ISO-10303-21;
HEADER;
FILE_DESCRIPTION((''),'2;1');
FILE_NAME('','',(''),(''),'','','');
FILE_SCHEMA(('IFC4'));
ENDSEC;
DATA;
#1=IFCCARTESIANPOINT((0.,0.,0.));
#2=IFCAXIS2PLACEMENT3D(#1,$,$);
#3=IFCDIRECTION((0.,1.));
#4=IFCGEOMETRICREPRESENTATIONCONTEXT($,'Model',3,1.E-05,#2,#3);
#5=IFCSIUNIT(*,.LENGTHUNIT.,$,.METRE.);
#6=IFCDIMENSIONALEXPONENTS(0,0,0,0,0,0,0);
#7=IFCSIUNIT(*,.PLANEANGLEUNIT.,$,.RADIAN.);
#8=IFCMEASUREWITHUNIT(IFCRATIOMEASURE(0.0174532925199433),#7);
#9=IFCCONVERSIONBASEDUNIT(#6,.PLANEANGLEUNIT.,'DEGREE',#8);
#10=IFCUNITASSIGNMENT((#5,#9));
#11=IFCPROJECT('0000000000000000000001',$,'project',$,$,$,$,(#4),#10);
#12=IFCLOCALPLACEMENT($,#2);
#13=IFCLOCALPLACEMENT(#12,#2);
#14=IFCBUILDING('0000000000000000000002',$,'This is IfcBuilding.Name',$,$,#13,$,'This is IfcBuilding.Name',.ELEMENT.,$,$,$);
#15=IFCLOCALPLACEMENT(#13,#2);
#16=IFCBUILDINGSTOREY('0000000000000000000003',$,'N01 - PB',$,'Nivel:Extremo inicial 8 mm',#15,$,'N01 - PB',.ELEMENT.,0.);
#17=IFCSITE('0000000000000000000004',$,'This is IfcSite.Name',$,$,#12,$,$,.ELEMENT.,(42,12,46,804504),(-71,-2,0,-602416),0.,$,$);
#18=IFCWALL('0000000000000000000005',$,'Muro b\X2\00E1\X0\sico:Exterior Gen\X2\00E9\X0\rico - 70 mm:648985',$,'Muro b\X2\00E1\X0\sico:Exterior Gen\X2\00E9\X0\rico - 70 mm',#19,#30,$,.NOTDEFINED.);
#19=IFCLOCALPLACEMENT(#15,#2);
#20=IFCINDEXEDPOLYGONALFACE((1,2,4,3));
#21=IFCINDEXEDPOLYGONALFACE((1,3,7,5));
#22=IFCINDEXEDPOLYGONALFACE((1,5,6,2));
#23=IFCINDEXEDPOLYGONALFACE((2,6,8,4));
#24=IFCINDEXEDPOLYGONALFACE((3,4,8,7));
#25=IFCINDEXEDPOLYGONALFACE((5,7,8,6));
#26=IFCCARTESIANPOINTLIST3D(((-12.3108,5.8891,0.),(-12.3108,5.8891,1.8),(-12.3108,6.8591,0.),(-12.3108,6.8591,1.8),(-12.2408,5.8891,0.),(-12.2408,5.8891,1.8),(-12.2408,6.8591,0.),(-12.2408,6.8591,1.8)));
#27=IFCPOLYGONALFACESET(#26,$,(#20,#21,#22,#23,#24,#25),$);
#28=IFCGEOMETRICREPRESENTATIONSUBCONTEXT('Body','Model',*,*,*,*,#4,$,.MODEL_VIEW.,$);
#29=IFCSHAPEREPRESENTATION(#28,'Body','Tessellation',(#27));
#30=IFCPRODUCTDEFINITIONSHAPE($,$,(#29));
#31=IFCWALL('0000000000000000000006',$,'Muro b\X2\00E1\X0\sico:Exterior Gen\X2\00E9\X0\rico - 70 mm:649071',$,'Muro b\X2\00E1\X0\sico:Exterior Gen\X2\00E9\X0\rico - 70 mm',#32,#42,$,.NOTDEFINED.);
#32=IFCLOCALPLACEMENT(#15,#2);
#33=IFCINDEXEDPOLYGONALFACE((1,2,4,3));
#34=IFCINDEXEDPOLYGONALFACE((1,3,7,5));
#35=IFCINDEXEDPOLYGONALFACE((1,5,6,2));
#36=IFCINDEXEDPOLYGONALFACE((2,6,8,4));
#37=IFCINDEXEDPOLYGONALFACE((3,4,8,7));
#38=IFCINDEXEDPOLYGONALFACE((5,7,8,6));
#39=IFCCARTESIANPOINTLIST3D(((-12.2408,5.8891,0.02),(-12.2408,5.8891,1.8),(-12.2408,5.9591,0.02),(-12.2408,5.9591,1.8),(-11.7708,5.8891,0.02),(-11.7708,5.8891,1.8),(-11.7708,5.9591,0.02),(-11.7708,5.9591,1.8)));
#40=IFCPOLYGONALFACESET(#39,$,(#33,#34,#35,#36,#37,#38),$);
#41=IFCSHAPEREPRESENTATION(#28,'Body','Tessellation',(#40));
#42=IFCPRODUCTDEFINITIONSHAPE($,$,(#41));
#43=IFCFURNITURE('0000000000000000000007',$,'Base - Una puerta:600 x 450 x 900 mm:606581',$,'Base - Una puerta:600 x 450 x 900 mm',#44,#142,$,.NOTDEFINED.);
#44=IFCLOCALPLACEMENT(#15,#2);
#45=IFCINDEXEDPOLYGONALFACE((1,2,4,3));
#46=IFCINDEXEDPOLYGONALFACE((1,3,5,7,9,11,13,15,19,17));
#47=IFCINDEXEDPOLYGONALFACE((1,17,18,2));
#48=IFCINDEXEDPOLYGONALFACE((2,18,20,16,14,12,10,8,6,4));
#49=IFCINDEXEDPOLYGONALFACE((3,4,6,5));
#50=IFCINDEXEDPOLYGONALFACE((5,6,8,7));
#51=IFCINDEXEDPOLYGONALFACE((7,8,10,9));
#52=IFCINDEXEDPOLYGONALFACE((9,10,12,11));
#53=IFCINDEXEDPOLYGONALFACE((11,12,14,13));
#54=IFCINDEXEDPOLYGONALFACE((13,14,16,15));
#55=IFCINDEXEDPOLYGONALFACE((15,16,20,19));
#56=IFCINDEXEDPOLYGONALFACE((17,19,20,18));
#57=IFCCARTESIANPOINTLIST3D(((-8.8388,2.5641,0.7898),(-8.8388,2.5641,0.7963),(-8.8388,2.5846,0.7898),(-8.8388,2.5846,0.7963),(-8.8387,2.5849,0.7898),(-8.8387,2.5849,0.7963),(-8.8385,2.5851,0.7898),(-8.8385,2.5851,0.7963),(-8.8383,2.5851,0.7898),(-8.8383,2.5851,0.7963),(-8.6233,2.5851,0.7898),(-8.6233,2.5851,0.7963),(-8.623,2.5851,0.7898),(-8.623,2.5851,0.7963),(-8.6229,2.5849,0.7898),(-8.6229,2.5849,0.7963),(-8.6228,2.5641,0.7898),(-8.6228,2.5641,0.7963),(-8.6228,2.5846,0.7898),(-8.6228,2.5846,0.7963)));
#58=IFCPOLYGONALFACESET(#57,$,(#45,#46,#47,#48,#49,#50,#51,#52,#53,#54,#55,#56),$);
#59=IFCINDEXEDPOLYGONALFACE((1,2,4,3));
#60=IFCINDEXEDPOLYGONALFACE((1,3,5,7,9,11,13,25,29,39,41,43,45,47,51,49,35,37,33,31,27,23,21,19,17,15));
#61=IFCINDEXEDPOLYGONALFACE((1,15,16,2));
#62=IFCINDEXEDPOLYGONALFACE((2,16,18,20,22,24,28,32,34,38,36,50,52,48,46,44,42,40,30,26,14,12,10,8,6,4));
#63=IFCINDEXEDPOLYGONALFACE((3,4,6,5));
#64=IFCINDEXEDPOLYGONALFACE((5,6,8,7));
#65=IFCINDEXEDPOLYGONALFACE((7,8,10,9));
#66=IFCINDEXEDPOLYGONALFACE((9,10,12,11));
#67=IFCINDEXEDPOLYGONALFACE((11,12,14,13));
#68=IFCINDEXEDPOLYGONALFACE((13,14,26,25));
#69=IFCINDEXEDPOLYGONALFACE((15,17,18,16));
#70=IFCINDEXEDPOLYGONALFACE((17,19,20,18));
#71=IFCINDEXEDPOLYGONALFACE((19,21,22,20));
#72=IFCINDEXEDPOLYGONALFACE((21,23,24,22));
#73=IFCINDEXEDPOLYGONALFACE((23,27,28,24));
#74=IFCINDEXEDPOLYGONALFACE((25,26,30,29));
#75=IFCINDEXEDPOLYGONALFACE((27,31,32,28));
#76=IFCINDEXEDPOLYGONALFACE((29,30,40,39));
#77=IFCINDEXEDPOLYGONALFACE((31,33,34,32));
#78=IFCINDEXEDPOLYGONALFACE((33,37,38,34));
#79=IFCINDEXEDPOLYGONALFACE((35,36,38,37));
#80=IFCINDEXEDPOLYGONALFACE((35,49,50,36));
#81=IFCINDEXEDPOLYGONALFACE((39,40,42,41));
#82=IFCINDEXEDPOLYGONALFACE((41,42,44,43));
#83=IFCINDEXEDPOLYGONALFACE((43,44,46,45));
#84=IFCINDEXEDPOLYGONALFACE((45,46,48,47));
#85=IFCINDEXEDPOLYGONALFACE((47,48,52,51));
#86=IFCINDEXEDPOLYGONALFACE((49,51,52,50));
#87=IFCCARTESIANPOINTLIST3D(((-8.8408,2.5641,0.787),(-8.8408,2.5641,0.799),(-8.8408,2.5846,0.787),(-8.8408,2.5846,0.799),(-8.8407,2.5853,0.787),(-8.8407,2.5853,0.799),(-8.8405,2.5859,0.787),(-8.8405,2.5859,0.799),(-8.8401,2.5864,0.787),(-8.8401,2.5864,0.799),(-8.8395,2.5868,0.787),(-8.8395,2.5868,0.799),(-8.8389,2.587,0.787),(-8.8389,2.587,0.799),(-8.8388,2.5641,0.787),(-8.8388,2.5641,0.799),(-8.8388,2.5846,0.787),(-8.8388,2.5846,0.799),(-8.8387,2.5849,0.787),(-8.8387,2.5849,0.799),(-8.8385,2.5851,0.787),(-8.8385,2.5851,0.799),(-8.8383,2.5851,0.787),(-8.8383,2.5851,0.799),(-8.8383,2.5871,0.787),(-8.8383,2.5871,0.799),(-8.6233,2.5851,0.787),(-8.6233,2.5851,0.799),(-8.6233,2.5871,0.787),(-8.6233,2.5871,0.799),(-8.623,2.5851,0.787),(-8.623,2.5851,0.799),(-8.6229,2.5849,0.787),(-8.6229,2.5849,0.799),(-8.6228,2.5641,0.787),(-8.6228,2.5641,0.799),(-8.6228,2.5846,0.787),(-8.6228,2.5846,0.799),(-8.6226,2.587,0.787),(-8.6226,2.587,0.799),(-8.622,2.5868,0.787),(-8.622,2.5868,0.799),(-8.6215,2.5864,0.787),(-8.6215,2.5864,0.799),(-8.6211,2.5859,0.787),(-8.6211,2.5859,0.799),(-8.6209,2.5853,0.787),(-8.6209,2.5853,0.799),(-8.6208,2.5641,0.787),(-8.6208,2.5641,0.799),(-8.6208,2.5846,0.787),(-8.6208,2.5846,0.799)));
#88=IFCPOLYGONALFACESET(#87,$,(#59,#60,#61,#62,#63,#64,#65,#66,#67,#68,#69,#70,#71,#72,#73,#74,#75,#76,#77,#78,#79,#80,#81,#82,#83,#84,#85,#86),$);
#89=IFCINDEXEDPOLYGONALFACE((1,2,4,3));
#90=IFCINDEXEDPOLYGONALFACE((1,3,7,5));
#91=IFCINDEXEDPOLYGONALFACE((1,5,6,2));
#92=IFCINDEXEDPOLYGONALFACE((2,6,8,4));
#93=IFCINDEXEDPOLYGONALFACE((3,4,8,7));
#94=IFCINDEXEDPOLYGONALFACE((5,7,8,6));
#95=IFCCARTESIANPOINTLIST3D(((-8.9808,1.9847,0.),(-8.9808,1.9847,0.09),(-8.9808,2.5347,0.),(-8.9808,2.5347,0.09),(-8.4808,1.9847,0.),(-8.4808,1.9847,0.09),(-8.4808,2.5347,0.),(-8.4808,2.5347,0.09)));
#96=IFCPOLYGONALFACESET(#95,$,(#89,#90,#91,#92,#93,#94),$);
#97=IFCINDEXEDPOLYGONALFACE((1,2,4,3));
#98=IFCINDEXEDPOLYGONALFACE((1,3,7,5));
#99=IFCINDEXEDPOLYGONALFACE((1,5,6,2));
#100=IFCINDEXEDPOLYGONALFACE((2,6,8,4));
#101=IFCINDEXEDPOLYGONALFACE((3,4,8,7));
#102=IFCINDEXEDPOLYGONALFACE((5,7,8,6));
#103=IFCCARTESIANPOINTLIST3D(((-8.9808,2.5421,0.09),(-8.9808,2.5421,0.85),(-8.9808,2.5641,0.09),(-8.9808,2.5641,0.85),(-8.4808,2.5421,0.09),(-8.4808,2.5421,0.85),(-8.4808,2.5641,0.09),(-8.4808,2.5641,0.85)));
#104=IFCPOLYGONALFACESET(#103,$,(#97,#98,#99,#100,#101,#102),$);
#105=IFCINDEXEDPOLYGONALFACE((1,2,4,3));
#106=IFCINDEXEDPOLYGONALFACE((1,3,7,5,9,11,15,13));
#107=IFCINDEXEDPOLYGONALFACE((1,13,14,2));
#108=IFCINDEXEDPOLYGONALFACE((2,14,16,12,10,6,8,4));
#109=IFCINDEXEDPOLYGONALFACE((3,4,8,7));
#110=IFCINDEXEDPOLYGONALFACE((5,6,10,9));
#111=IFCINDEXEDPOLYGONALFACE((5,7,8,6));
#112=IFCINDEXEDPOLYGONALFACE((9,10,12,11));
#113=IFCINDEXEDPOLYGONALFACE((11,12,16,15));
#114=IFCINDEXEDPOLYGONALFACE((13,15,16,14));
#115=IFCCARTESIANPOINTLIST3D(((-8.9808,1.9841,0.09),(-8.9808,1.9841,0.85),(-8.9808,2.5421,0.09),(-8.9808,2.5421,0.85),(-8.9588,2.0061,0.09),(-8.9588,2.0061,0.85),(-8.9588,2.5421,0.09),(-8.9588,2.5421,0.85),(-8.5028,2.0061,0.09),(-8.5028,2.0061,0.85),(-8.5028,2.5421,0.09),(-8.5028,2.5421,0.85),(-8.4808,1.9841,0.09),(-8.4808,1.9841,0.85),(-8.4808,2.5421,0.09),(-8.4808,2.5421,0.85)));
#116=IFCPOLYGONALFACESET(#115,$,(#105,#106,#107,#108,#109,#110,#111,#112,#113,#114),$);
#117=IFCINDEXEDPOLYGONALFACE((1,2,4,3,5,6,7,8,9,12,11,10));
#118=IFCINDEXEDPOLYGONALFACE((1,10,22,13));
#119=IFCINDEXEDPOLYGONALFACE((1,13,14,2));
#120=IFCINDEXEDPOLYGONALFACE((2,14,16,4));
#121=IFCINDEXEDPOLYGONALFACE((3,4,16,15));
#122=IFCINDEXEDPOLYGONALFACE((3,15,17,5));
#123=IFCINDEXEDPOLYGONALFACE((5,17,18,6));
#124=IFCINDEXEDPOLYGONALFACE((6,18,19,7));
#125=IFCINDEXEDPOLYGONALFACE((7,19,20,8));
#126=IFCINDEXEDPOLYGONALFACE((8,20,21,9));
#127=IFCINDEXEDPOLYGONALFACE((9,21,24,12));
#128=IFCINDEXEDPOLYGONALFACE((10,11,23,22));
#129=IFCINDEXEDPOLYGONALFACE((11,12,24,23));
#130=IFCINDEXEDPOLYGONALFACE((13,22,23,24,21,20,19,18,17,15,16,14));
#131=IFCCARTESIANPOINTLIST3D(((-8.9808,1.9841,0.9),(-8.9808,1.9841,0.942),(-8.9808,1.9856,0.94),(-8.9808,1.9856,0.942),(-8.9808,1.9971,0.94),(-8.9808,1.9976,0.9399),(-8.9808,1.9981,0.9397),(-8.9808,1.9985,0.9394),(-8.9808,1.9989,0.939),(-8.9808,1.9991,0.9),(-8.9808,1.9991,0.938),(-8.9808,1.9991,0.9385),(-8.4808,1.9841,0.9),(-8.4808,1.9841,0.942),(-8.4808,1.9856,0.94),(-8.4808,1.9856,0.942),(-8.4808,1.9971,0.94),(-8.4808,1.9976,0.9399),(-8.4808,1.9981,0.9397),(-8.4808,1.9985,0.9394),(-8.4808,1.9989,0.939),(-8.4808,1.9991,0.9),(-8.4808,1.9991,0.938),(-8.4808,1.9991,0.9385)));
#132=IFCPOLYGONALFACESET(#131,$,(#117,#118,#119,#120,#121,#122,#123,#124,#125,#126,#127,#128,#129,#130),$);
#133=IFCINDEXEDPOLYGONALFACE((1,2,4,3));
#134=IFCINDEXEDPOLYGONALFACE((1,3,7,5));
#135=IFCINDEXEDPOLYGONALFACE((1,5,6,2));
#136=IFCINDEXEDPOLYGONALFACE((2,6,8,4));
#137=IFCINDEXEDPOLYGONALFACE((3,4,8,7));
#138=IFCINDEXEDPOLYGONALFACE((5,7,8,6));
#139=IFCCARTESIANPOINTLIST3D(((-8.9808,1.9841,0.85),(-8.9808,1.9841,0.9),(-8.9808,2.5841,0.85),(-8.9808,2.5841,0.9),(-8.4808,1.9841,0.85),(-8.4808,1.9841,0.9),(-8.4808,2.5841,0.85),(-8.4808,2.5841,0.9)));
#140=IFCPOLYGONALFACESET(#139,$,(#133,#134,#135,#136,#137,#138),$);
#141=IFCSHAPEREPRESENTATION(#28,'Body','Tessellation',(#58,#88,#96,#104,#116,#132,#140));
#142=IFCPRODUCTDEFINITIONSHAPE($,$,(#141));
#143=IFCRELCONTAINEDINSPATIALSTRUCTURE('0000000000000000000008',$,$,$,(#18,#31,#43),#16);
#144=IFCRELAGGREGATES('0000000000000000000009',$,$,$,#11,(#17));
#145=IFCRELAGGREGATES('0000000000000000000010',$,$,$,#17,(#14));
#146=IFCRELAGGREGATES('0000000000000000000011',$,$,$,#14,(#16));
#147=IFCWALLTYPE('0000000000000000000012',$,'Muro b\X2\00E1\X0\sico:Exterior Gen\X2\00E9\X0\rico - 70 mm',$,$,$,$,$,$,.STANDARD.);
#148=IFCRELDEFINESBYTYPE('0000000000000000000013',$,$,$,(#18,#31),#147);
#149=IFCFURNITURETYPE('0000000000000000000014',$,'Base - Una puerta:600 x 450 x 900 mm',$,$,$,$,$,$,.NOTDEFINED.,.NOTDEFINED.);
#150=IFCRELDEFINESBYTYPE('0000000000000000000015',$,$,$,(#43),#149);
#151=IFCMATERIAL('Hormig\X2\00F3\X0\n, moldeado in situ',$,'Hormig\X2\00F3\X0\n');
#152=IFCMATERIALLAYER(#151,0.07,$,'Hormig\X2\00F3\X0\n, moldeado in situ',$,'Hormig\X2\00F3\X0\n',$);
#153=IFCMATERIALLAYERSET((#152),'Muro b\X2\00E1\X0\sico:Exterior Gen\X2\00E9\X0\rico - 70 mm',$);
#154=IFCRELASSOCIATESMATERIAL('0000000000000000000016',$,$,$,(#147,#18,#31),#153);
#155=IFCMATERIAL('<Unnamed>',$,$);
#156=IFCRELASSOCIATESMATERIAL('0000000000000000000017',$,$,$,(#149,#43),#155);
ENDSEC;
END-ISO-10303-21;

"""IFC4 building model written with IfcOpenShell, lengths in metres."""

from ifc_helpers import new_model, entity, si_unit, converted_unit, direction, frame, frame_2d, origin, origin_2d_with_axis, place, context, subcontext, project, spatial, polyline, circle_curve, parameter, trimmed, segment, composite_curve, rectangle, outline, extrude, clip, bounded_halfspace, source, transform, mapped, material, layer, layer_set, layer_usage, type_object, type_shapes, element, save


model = new_model("IFC4")

# Units and contexts
model_context = context("Model", 3, precision=1e-05, world=origin(), true_north=direction((0.0, 1.0)))
body_context = subcontext(model_context, "Body", "Model", "MODEL_VIEW")
ifc_project = project(units=[si_unit("LENGTHUNIT", "METRE"), converted_unit("PLANEANGLEUNIT", "DEGREE", entity("IfcRatioMeasure", 0.0174532925199433), si_unit("PLANEANGLEUNIT", "RADIAN"), dimensions=[0, 0, 0, 0, 0, 0, 0])], contexts=[model_context])

# Site, building, storey
site_placement = place(None, origin())
site = spatial("IfcSite", under=ifc_project, at=site_placement, Name="This is IfcSite.Name", CompositionType="ELEMENT", RefLatitude=(42, 12, 46, 804504), RefLongitude=(-71, -2, 0, -602416), RefElevation=0.0)
building_placement = place(site_placement, origin())
building = spatial("IfcBuilding", under=site, at=building_placement, Name="This is IfcBuilding.Name", LongName="This is IfcBuilding.Name", CompositionType="ELEMENT")
storey_placement = place(building_placement, origin())
storey = spatial("IfcBuildingStorey", under=building, at=storey_placement, Name="N01 - PB", ObjectType="Nivel:Extremo inicial 8 mm", LongName="N01 - PB", CompositionType="ELEMENT", Elevation=0.0)

# Shared definitions
ifc_material_1 = material(Name="Hormigón, moldeado in situ", Category="Hormigón")

# Walls
ifc_layer_1 = layer(ifc_material_1, 0.07, Name="Hormigón, moldeado in situ", Category="Hormigón")
ifc_layer_set_1 = layer_set([ifc_layer_1], Name="Muro básico:Exterior Genérico - 70 mm")
wall_type_1 = type_object("IfcWallType", Name="Muro básico:Exterior Genérico - 70 mm", PredefinedType="STANDARD", material=ifc_layer_set_1)
ifc_layer_usage_1 = layer_usage(ifc_layer_set_1, "AXIS2", "POSITIVE", -0.035)
wall_1_placement = place(storey_placement, frame((-12.2758, 6.8591, 0.0), z_axis=(0.0, 0.0, 1.0), x_axis=(0.0, -1.0, 0.0)))
element("IfcWall", 1, at=wall_1_placement, inside=storey, type_object=wall_type_1, material=ifc_layer_usage_1, Name="Muro básico:Exterior Genérico - 70 mm:648985", ObjectType="Muro básico:Exterior Genérico - 70 mm", PredefinedType="NOTDEFINED", context=body_context, shape_type="Clipping", body=[
    clip(extrude(rectangle(XDim=0.97, YDim=0.07, at=frame_2d((0.485, 0.0), x_axis=(-1.0, 0.0))), origin(), (0.0, 0.0, 1.0), 1.8), bounded_halfspace(frame((0.0, -0.035, 1.8), z_axis=(0.0, 0.0, 1.0), x_axis=(0.0, 1.0, 0.0)), False, frame((0.0, -0.035, 1.8)), polyline([(0.0, 0.0), (0.97, 0.0), (0.97, 0.07), (0.9, 0.07), (0.0, 0.07), (0.0, 0.0)]))),
])
ifc_layer_usage_2 = layer_usage(ifc_layer_set_1, "AXIS2", "POSITIVE", -0.035)
wall_2_placement = place(storey_placement, frame((-12.2408, 5.9241, 0.02)))
element("IfcWall", 2, at=wall_2_placement, inside=storey, type_object=wall_type_1, material=ifc_layer_usage_2, Name="Muro básico:Exterior Genérico - 70 mm:649071", ObjectType="Muro básico:Exterior Genérico - 70 mm", PredefinedType="NOTDEFINED", context=body_context, shape_type="Clipping", body=[
    clip(extrude(rectangle(XDim=0.47, YDim=0.07, at=frame_2d((0.235, 0.0), x_axis=(-1.0, 0.0))), origin(), (0.0, 0.0, 1.0), 1.78), bounded_halfspace(frame((0.0, -0.035, 1.78)), False, frame((0.0, -0.035, 1.78)), polyline([(0.0, 0.0), (0.47, 0.0), (0.47, 0.07), (0.0, 0.07), (0.0, 0.0)]))),
])

# Furniture
ifc_material_2 = material(Name="<Unnamed>")
furniture_type_1 = type_object("IfcFurnitureType", Name="Base - Una puerta:600 x 450 x 900 mm", AssemblyPlace="NOTDEFINED", PredefinedType="NOTDEFINED", material=ifc_material_2)
shared_shape_1 = source(origin(), body_context, "Body", "SweptSolid", [
    extrude(outline(composite_curve([segment(polyline([(-0.0138, -0.108), (0.0067, -0.108)]), True, "CONTINUOUS"), segment(trimmed(circle_curve(frame_2d((0.0067, -0.1075), x_axis=(0.0, -1.0)), 0.0005), [parameter(0.0)], [parameter(90.0)], True, "PARAMETER"), True, "CONTINUOUS"), segment(polyline([(0.0072, -0.1075), (0.0072, 0.1075)]), True, "CONTINUOUS"), segment(trimmed(circle_curve(frame_2d((0.0067, 0.1075), x_axis=(1.0, 0.0)), 0.0005), [parameter(0.0)], [parameter(90.0)], True, "PARAMETER"), True, "CONTINUOUS"), segment(polyline([(0.0067, 0.108), (-0.0138, 0.108)]), True, "CONTINUOUS"), segment(polyline([(-0.0138, 0.108), (-0.0138, -0.108)]), True, "CONTINUOUS")], self_intersect=False)), frame((0.0447, -0.5938, 0.7898), z_axis=(0.0, 0.0, 1.0), x_axis=(0.0, -1.0, 0.0)), (0.0, 0.0, 1.0), 0.0065),
    extrude(outline(composite_curve([segment(polyline([(-0.0142, -0.11), (0.0063, -0.11)]), True, "CONTINUOUS"), segment(trimmed(circle_curve(frame_2d((0.0063, -0.1075), x_axis=(0.0, -1.0)), 0.0025), [parameter(0.0)], [parameter(90.0)], True, "PARAMETER"), True, "CONTINUOUS"), segment(polyline([(0.0088, -0.1075), (0.0088, 0.1075)]), True, "CONTINUOUS"), segment(trimmed(circle_curve(frame_2d((0.0063, 0.1075), x_axis=(1.0, 0.0)), 0.0025), [parameter(0.0)], [parameter(90.0)], True, "PARAMETER"), True, "CONTINUOUS"), segment(polyline([(0.0063, 0.11), (-0.0142, 0.11)]), True, "CONTINUOUS"), segment(polyline([(-0.0142, 0.11), (-0.0142, 0.108)]), True, "CONTINUOUS"), segment(polyline([(-0.0142, 0.108), (0.0063, 0.108)]), True, "CONTINUOUS"), segment(trimmed(circle_curve(frame_2d((0.0063, 0.1075), x_axis=(1.0, 0.0)), 0.0005), [parameter(0.0)], [parameter(90.0)], True, "PARAMETER"), False, "CONTINUOUS"), segment(polyline([(0.0068, 0.1075), (0.0068, -0.1075)]), True, "CONTINUOUS"), segment(trimmed(circle_curve(frame_2d((0.0063, -0.1075), x_axis=(0.0, -1.0)), 0.0005), [parameter(0.0)], [parameter(90.0)], True, "PARAMETER"), False, "CONTINUOUS"), segment(polyline([(0.0063, -0.108), (-0.0142, -0.108)]), True, "CONTINUOUS"), segment(polyline([(-0.0142, -0.108), (-0.0142, -0.11)]), True, "CONTINUOUS")], self_intersect=False)), frame((0.0447, -0.5942, 0.787), z_axis=(0.0, 0.0, 1.0), x_axis=(0.0, -1.0, 0.0)), (0.0, 0.0, 1.0), 0.012),
    extrude(rectangle(XDim=0.5, YDim=0.55, at=origin_2d_with_axis()), frame((0.0447, -0.2755, 0.0), z_axis=(0.0, 0.0, 1.0), x_axis=(-1.0, 0.0, 0.0)), (0.0, 0.0, 1.0), 0.09),
    extrude(rectangle(XDim=0.022, YDim=0.5, at=frame_2d((0.0, 0.0), x_axis=(1.0, 0.0))), frame((0.0447, -0.569, 0.09), z_axis=(0.0, 0.0, 1.0), x_axis=(0.0, 1.0, 0.0)), (0.0, 0.0, 1.0), 0.76),
    extrude(outline(polyline([(-0.25, -0.2845), (0.25, -0.2845), (0.25, 0.2735), (0.228, 0.2735), (0.228, -0.2625), (-0.228, -0.2625), (-0.228, 0.2735), (-0.25, 0.2735), (-0.25, -0.2845)])), frame((0.0447, -0.2845, 0.09), z_axis=(0.0, 0.0, 1.0), x_axis=(-1.0, 0.0, 0.0)), (0.0, 0.0, 1.0), 0.76),
    extrude(outline(composite_curve([segment(polyline([(-0.0066, -0.0131), (-0.0051, -0.0131)]), True, "CONTINUOUS"), segment(polyline([(-0.0051, -0.0131), (-0.0051, -0.0111)]), True, "CONTINUOUS"), segment(polyline([(-0.0051, -0.0111), (0.0064, -0.0111)]), True, "CONTINUOUS"), segment(trimmed(circle_curve(frame_2d((0.0064, -0.0091), x_axis=(1.0, 0.0)), 0.002), [parameter(270.0)], [parameter(0.0)], True, "PARAMETER"), True, "CONTINUOUS"), segment(polyline([(0.0084, -0.0091), (0.0084, 0.0289)]), True, "CONTINUOUS"), segment(polyline([(0.0084, 0.0289), (-0.0066, 0.0289)]), True, "CONTINUOUS"), segment(polyline([(-0.0066, 0.0289), (-0.0066, -0.0131)]), True, "CONTINUOUS")], self_intersect=False)), frame((-0.2053, -0.0066, 0.9289), z_axis=(1.0, 0.0, 0.0), x_axis=(0.0, -1.0, 0.0)), (0.0, 0.0, 1.0), 0.5),
    extrude(rectangle(XDim=0.5, YDim=0.6, at=origin_2d_with_axis()), frame((0.0447, -0.3, 0.85), z_axis=(0.0, 0.0, 1.0), x_axis=(-1.0, 0.0, 0.0)), (0.0, 0.0, 1.0), 0.05),
])
type_shapes(furniture_type_1, [shared_shape_1])
furniture_1_placement = place(storey_placement, frame((-8.6861, 1.9841, 0.0), z_axis=(0.0, 0.0, 1.0), x_axis=(-1.0, 0.0, 0.0)))
element("IfcFurniture", 3, at=furniture_1_placement, inside=storey, type_object=furniture_type_1, material=ifc_material_2, Name="Base - Una puerta:600 x 450 x 900 mm:606581", ObjectType="Base - Una puerta:600 x 450 x 900 mm", PredefinedType="NOTDEFINED", context=body_context, shape_type="MappedRepresentation", body=[
    mapped(shared_shape_1, transform((0.0, 0.0, 0.0), scale=1.0)),
])

save(model, "model.ifc")
